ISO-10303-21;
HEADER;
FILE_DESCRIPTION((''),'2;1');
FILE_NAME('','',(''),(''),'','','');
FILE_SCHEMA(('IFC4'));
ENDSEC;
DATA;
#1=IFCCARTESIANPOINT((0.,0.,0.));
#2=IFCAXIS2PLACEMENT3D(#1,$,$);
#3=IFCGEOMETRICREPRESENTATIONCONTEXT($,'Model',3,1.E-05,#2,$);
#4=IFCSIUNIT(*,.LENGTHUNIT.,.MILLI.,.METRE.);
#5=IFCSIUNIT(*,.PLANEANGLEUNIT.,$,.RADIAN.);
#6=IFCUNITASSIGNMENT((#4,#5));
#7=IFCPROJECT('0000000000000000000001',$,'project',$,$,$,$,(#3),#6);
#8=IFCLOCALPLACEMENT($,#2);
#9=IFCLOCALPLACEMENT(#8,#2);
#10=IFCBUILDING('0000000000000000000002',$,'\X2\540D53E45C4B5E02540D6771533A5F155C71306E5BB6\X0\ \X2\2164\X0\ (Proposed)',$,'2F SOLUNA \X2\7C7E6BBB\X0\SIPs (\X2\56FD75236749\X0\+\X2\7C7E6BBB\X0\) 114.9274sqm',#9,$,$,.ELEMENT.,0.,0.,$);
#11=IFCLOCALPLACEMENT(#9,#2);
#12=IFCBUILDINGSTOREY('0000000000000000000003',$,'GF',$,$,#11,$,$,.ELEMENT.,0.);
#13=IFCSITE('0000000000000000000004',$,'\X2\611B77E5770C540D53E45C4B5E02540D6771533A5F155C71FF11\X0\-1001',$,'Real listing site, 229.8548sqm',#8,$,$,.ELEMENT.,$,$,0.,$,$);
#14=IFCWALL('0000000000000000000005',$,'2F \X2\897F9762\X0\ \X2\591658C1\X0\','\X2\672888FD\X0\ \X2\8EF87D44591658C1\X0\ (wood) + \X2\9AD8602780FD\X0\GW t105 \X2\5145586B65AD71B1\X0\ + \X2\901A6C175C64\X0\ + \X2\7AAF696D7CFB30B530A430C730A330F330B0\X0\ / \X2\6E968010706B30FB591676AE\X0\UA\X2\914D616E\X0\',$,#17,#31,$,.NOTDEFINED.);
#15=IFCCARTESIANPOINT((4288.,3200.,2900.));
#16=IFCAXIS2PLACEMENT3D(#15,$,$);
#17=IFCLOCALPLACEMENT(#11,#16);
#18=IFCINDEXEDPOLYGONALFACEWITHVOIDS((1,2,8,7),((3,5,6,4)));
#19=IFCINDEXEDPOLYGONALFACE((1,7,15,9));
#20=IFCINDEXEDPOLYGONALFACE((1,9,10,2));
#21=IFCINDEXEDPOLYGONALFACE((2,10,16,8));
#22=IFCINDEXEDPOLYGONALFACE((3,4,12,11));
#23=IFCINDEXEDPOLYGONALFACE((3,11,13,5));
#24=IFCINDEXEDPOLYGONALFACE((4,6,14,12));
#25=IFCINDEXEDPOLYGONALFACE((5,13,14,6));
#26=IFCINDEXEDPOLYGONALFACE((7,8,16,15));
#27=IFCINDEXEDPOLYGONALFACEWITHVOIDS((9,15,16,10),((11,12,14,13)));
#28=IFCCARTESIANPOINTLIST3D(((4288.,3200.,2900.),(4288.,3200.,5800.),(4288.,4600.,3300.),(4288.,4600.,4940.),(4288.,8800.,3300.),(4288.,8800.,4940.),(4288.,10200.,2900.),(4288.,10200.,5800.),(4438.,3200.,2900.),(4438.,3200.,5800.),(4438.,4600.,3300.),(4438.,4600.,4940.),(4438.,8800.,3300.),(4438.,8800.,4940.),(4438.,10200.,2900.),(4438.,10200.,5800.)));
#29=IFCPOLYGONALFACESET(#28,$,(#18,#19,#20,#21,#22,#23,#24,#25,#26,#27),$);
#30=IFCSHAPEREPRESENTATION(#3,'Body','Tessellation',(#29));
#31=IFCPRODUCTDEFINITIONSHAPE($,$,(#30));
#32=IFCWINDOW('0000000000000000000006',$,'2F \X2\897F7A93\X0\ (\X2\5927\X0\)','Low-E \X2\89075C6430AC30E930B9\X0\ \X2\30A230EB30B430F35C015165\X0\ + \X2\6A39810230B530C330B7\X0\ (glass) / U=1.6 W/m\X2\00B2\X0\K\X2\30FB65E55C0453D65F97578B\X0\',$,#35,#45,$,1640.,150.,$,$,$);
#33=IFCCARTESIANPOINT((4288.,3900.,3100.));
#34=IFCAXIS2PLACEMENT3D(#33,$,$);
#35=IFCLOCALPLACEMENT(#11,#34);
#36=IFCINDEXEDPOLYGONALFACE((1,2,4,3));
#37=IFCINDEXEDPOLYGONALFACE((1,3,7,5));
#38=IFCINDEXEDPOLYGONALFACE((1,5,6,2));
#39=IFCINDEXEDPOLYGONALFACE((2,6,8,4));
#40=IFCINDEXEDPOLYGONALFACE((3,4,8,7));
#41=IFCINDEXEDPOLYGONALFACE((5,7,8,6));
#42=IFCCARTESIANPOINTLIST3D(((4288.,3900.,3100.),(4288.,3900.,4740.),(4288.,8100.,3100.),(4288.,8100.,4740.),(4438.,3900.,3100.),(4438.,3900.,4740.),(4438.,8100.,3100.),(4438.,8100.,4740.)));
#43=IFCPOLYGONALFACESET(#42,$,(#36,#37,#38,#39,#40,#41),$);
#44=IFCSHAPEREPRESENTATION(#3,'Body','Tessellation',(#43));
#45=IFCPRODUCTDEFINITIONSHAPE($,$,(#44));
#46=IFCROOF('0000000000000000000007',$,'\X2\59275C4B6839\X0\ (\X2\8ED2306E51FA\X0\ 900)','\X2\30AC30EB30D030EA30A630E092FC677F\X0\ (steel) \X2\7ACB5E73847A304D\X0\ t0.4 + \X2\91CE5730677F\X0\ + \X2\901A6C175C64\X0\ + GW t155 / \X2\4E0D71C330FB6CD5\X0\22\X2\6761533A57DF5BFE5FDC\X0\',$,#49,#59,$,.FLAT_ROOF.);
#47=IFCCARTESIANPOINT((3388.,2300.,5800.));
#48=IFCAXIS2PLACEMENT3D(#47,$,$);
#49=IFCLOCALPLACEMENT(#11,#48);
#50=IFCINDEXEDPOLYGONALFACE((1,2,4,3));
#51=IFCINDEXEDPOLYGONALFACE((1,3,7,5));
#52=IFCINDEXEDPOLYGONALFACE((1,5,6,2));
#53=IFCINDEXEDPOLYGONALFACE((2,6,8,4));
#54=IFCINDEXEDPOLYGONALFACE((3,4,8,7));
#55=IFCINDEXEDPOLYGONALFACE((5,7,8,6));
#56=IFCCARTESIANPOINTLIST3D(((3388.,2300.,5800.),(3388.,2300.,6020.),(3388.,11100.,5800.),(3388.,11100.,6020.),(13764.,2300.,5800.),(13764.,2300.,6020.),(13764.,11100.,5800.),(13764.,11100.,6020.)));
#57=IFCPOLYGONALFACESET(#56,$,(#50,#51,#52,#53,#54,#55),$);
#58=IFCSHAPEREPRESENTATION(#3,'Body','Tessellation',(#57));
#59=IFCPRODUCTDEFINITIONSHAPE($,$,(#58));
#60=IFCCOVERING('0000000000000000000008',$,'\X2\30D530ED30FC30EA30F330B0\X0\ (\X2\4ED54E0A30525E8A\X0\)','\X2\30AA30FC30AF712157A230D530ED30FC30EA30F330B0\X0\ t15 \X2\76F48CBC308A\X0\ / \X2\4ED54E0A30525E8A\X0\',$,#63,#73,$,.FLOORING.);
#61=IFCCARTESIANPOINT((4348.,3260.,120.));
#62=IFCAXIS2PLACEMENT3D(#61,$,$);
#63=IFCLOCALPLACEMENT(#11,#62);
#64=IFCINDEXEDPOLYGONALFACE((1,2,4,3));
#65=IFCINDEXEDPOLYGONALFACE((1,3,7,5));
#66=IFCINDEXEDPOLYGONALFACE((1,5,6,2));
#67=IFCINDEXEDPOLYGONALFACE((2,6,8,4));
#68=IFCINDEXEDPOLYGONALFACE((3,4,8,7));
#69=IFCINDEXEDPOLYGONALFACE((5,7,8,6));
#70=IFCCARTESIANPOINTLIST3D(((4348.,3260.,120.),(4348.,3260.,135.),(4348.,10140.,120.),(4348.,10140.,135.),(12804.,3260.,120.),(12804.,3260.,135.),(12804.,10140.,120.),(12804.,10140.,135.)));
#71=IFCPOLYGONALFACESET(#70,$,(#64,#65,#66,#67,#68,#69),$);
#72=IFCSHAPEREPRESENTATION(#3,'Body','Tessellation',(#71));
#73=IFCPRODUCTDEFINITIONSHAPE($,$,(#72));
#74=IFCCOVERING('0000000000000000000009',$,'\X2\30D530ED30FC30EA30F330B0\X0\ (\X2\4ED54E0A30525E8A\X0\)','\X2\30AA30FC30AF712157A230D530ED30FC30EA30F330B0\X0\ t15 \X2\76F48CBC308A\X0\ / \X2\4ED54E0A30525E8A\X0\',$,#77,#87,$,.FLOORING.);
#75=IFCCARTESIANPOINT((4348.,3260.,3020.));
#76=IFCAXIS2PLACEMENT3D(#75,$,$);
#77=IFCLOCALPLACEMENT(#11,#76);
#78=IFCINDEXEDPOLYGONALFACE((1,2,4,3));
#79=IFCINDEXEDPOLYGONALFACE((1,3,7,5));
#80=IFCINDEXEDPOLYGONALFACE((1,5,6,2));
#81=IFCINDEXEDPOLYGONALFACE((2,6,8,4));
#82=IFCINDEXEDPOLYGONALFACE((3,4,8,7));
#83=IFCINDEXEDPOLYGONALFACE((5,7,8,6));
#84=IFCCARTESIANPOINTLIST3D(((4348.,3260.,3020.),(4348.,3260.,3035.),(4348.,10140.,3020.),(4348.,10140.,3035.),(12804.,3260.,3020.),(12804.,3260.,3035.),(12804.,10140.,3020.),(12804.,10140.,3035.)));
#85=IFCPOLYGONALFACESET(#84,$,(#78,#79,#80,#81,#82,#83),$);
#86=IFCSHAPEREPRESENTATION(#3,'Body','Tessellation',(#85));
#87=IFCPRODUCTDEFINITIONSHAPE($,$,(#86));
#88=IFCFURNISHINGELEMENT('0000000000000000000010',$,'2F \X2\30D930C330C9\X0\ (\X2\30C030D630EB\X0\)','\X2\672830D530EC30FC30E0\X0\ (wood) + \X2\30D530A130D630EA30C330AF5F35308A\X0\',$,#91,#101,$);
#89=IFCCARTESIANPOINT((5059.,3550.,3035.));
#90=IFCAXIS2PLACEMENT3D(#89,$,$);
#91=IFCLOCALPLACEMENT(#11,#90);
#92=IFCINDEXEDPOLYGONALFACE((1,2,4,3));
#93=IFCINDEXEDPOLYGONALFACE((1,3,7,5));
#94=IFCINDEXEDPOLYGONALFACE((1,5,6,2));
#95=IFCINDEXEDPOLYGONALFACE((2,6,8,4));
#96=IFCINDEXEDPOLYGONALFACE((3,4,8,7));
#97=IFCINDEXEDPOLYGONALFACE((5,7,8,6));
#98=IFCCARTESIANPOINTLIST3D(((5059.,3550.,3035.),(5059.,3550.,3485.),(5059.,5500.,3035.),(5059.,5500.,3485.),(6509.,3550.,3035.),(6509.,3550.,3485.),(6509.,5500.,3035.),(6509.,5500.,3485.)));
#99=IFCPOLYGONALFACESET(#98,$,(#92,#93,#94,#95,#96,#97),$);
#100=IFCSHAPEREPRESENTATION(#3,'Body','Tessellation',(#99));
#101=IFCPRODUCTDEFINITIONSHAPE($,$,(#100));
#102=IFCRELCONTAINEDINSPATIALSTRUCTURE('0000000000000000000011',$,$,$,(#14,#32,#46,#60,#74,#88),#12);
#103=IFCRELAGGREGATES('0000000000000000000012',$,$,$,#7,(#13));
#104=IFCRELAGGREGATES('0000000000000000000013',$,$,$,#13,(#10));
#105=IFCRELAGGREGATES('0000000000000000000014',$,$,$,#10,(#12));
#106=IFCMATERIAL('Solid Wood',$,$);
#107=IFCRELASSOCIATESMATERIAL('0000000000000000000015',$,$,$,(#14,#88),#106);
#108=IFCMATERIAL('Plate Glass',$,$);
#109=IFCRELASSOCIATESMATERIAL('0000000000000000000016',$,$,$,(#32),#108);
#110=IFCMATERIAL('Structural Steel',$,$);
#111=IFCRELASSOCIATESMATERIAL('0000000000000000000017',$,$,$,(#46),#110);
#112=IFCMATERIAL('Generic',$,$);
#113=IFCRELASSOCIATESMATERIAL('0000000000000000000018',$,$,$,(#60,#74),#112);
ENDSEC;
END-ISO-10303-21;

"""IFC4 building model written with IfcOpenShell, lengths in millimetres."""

from ifc_helpers import new_model, si_unit, frame, frame_2d, origin, place, context, project, spatial, rectangle, extrude, material, element, fill, save


model = new_model("IFC4")

# Units and contexts
model_context = context("Model", 3, precision=1e-05, world=origin())
ifc_project = project(units=[si_unit("LENGTHUNIT", "METRE", prefix="MILLI"), si_unit("PLANEANGLEUNIT", "RADIAN")], contexts=[model_context])

# Site, building, storey
site_placement = place(None, origin())
site = spatial("IfcSite", under=ifc_project, at=site_placement, Name="愛知県名古屋市名東区引山１-1001", ObjectType="Real listing site, 229.8548sqm", CompositionType="ELEMENT", RefElevation=0.0)
building_placement = place(site_placement, origin())
building = spatial("IfcBuilding", under=site, at=building_placement, Name="名古屋市名東区引山の家 Ⅴ (Proposed)", ObjectType="2F SOLUNA 籾殻SIPs (国産杉+籾殻) 114.9274sqm", CompositionType="ELEMENT", ElevationOfRefHeight=0.0, ElevationOfTerrain=0.0)
storey_placement = place(building_placement, origin())
storey = spatial("IfcBuildingStorey", under=building, at=storey_placement, Name="GF", CompositionType="ELEMENT", Elevation=0.0)

# Shared definitions
ifc_material_1 = material(Name="Solid Wood")

# Shared definitions
ifc_material_2 = material(Name="Plate Glass")

# Wall, opening, window
wall_1_placement = place(storey_placement, frame((4288.0, 3200.0, 2900.0)))
wall_1 = element("IfcWall", 1, at=wall_1_placement, inside=storey, material=ifc_material_1, Name="2F 西面 外壁", Description="木製 軸組外壁 (wood) + 高性能GW t105 充填断熱 + 通気層 + 窯業系サイディング / 準耐火・外皮UA配慮", PredefinedType="NOTDEFINED", context=model_context, shape_type="SweptSolid", body=[
    extrude(rectangle(XDim=150.0, YDim=7000.0, at=frame_2d((75.0, 3500.0))), frame((4288.0, 3200.0, 2900.0)), (0.0, 0.0, 1.0), 2900.0),
])
opening_1_placement = place(storey_placement, frame((4288.0, 3900.0, 3100.0)))
opening_1 = element("IfcOpeningElement", 2, at=opening_1_placement, cuts=wall_1, PredefinedType="NOTDEFINED", context=model_context, shape_type="SweptSolid", body=[
    extrude(rectangle(XDim=150.0, YDim=4200.0, at=frame_2d((75.0, 2100.0))), frame((4288.0, 3900.0, 3100.0)), (0.0, 0.0, 1.0), 1640.0),
])
window_1_placement = place(storey_placement, frame((4288.0, 3900.0, 3100.0)))
window_1 = element("IfcWindow", 3, at=window_1_placement, inside=storey, material=ifc_material_2, Name="2F 西窓 (大)", Description="Low-E 複層ガラス アルゴン封入 + 樹脂サッシ (glass) / U=1.6 W/m²K・日射取得型", OverallHeight=1640.0, OverallWidth=150.0, context=model_context, shape_type="SweptSolid", body=[
    extrude(rectangle(XDim=150.0, YDim=4200.0, at=frame_2d((75.0, 2100.0))), frame((4288.0, 3900.0, 3100.0)), (0.0, 0.0, 1.0), 1640.0),
])
fill(opening_1, window_1)

# Roof
ifc_material_3 = material(Name="Structural Steel")
roof_placement = place(storey_placement, frame((3388.0, 2300.0, 5800.0)))
element("IfcRoof", 4, at=roof_placement, inside=storey, material=ifc_material_3, Name="大屋根 (軒の出 900)", Description="ガルバリウム鋼板 (steel) 立平葺き t0.4 + 野地板 + 通気層 + GW t155 / 不燃・法22条区域対応", PredefinedType="FLAT_ROOF", context=model_context, shape_type="SweptSolid", body=[
    extrude(rectangle(XDim=10376.0, YDim=8800.0, at=frame_2d((5188.0, 4400.0))), frame((3388.0, 2300.0, 5800.0)), (0.0, 0.0, 1.0), 220.0),
])

# Coverings
ifc_material_4 = material(Name="Generic")
covering_1_placement = place(storey_placement, frame((4348.0, 3260.0, 120.0)))
element("IfcCovering", 5, at=covering_1_placement, inside=storey, material=ifc_material_4, Name="フローリング (仕上げ床)", Description="オーク無垢フローリング t15 直貼り / 仕上げ床", PredefinedType="FLOORING", context=model_context, shape_type="SweptSolid", body=[
    extrude(rectangle(XDim=8456.0, YDim=6880.0, at=frame_2d((4228.0, 3440.0))), frame((4348.0, 3260.0, 120.0)), (0.0, 0.0, 1.0), 15.0),
])
covering_2_placement = place(storey_placement, frame((4348.0, 3260.0, 3020.0)))
element("IfcCovering", 6, at=covering_2_placement, inside=storey, material=ifc_material_4, Name="フローリング (仕上げ床)", Description="オーク無垢フローリング t15 直貼り / 仕上げ床", PredefinedType="FLOORING", context=model_context, shape_type="SweptSolid", body=[
    extrude(rectangle(XDim=8456.0, YDim=6880.0, at=frame_2d((4228.0, 3440.0))), frame((4348.0, 3260.0, 3020.0)), (0.0, 0.0, 1.0), 15.0),
])

# Furnishing element
furnishing_placement = place(storey_placement, frame((5059.0, 3550.0, 3035.0)))
element("IfcFurnishingElement", 7, at=furnishing_placement, inside=storey, material=ifc_material_1, Name="2F ベッド (ダブル)", Description="木フレーム (wood) + ファブリック張り", context=model_context, shape_type="SweptSolid", body=[
    extrude(rectangle(XDim=1450.0, YDim=1950.0, at=frame_2d((725.0, 975.0))), frame((5059.0, 3550.0, 3035.0)), (0.0, 0.0, 1.0), 450.0),
])

save(model, "model.ifc")
